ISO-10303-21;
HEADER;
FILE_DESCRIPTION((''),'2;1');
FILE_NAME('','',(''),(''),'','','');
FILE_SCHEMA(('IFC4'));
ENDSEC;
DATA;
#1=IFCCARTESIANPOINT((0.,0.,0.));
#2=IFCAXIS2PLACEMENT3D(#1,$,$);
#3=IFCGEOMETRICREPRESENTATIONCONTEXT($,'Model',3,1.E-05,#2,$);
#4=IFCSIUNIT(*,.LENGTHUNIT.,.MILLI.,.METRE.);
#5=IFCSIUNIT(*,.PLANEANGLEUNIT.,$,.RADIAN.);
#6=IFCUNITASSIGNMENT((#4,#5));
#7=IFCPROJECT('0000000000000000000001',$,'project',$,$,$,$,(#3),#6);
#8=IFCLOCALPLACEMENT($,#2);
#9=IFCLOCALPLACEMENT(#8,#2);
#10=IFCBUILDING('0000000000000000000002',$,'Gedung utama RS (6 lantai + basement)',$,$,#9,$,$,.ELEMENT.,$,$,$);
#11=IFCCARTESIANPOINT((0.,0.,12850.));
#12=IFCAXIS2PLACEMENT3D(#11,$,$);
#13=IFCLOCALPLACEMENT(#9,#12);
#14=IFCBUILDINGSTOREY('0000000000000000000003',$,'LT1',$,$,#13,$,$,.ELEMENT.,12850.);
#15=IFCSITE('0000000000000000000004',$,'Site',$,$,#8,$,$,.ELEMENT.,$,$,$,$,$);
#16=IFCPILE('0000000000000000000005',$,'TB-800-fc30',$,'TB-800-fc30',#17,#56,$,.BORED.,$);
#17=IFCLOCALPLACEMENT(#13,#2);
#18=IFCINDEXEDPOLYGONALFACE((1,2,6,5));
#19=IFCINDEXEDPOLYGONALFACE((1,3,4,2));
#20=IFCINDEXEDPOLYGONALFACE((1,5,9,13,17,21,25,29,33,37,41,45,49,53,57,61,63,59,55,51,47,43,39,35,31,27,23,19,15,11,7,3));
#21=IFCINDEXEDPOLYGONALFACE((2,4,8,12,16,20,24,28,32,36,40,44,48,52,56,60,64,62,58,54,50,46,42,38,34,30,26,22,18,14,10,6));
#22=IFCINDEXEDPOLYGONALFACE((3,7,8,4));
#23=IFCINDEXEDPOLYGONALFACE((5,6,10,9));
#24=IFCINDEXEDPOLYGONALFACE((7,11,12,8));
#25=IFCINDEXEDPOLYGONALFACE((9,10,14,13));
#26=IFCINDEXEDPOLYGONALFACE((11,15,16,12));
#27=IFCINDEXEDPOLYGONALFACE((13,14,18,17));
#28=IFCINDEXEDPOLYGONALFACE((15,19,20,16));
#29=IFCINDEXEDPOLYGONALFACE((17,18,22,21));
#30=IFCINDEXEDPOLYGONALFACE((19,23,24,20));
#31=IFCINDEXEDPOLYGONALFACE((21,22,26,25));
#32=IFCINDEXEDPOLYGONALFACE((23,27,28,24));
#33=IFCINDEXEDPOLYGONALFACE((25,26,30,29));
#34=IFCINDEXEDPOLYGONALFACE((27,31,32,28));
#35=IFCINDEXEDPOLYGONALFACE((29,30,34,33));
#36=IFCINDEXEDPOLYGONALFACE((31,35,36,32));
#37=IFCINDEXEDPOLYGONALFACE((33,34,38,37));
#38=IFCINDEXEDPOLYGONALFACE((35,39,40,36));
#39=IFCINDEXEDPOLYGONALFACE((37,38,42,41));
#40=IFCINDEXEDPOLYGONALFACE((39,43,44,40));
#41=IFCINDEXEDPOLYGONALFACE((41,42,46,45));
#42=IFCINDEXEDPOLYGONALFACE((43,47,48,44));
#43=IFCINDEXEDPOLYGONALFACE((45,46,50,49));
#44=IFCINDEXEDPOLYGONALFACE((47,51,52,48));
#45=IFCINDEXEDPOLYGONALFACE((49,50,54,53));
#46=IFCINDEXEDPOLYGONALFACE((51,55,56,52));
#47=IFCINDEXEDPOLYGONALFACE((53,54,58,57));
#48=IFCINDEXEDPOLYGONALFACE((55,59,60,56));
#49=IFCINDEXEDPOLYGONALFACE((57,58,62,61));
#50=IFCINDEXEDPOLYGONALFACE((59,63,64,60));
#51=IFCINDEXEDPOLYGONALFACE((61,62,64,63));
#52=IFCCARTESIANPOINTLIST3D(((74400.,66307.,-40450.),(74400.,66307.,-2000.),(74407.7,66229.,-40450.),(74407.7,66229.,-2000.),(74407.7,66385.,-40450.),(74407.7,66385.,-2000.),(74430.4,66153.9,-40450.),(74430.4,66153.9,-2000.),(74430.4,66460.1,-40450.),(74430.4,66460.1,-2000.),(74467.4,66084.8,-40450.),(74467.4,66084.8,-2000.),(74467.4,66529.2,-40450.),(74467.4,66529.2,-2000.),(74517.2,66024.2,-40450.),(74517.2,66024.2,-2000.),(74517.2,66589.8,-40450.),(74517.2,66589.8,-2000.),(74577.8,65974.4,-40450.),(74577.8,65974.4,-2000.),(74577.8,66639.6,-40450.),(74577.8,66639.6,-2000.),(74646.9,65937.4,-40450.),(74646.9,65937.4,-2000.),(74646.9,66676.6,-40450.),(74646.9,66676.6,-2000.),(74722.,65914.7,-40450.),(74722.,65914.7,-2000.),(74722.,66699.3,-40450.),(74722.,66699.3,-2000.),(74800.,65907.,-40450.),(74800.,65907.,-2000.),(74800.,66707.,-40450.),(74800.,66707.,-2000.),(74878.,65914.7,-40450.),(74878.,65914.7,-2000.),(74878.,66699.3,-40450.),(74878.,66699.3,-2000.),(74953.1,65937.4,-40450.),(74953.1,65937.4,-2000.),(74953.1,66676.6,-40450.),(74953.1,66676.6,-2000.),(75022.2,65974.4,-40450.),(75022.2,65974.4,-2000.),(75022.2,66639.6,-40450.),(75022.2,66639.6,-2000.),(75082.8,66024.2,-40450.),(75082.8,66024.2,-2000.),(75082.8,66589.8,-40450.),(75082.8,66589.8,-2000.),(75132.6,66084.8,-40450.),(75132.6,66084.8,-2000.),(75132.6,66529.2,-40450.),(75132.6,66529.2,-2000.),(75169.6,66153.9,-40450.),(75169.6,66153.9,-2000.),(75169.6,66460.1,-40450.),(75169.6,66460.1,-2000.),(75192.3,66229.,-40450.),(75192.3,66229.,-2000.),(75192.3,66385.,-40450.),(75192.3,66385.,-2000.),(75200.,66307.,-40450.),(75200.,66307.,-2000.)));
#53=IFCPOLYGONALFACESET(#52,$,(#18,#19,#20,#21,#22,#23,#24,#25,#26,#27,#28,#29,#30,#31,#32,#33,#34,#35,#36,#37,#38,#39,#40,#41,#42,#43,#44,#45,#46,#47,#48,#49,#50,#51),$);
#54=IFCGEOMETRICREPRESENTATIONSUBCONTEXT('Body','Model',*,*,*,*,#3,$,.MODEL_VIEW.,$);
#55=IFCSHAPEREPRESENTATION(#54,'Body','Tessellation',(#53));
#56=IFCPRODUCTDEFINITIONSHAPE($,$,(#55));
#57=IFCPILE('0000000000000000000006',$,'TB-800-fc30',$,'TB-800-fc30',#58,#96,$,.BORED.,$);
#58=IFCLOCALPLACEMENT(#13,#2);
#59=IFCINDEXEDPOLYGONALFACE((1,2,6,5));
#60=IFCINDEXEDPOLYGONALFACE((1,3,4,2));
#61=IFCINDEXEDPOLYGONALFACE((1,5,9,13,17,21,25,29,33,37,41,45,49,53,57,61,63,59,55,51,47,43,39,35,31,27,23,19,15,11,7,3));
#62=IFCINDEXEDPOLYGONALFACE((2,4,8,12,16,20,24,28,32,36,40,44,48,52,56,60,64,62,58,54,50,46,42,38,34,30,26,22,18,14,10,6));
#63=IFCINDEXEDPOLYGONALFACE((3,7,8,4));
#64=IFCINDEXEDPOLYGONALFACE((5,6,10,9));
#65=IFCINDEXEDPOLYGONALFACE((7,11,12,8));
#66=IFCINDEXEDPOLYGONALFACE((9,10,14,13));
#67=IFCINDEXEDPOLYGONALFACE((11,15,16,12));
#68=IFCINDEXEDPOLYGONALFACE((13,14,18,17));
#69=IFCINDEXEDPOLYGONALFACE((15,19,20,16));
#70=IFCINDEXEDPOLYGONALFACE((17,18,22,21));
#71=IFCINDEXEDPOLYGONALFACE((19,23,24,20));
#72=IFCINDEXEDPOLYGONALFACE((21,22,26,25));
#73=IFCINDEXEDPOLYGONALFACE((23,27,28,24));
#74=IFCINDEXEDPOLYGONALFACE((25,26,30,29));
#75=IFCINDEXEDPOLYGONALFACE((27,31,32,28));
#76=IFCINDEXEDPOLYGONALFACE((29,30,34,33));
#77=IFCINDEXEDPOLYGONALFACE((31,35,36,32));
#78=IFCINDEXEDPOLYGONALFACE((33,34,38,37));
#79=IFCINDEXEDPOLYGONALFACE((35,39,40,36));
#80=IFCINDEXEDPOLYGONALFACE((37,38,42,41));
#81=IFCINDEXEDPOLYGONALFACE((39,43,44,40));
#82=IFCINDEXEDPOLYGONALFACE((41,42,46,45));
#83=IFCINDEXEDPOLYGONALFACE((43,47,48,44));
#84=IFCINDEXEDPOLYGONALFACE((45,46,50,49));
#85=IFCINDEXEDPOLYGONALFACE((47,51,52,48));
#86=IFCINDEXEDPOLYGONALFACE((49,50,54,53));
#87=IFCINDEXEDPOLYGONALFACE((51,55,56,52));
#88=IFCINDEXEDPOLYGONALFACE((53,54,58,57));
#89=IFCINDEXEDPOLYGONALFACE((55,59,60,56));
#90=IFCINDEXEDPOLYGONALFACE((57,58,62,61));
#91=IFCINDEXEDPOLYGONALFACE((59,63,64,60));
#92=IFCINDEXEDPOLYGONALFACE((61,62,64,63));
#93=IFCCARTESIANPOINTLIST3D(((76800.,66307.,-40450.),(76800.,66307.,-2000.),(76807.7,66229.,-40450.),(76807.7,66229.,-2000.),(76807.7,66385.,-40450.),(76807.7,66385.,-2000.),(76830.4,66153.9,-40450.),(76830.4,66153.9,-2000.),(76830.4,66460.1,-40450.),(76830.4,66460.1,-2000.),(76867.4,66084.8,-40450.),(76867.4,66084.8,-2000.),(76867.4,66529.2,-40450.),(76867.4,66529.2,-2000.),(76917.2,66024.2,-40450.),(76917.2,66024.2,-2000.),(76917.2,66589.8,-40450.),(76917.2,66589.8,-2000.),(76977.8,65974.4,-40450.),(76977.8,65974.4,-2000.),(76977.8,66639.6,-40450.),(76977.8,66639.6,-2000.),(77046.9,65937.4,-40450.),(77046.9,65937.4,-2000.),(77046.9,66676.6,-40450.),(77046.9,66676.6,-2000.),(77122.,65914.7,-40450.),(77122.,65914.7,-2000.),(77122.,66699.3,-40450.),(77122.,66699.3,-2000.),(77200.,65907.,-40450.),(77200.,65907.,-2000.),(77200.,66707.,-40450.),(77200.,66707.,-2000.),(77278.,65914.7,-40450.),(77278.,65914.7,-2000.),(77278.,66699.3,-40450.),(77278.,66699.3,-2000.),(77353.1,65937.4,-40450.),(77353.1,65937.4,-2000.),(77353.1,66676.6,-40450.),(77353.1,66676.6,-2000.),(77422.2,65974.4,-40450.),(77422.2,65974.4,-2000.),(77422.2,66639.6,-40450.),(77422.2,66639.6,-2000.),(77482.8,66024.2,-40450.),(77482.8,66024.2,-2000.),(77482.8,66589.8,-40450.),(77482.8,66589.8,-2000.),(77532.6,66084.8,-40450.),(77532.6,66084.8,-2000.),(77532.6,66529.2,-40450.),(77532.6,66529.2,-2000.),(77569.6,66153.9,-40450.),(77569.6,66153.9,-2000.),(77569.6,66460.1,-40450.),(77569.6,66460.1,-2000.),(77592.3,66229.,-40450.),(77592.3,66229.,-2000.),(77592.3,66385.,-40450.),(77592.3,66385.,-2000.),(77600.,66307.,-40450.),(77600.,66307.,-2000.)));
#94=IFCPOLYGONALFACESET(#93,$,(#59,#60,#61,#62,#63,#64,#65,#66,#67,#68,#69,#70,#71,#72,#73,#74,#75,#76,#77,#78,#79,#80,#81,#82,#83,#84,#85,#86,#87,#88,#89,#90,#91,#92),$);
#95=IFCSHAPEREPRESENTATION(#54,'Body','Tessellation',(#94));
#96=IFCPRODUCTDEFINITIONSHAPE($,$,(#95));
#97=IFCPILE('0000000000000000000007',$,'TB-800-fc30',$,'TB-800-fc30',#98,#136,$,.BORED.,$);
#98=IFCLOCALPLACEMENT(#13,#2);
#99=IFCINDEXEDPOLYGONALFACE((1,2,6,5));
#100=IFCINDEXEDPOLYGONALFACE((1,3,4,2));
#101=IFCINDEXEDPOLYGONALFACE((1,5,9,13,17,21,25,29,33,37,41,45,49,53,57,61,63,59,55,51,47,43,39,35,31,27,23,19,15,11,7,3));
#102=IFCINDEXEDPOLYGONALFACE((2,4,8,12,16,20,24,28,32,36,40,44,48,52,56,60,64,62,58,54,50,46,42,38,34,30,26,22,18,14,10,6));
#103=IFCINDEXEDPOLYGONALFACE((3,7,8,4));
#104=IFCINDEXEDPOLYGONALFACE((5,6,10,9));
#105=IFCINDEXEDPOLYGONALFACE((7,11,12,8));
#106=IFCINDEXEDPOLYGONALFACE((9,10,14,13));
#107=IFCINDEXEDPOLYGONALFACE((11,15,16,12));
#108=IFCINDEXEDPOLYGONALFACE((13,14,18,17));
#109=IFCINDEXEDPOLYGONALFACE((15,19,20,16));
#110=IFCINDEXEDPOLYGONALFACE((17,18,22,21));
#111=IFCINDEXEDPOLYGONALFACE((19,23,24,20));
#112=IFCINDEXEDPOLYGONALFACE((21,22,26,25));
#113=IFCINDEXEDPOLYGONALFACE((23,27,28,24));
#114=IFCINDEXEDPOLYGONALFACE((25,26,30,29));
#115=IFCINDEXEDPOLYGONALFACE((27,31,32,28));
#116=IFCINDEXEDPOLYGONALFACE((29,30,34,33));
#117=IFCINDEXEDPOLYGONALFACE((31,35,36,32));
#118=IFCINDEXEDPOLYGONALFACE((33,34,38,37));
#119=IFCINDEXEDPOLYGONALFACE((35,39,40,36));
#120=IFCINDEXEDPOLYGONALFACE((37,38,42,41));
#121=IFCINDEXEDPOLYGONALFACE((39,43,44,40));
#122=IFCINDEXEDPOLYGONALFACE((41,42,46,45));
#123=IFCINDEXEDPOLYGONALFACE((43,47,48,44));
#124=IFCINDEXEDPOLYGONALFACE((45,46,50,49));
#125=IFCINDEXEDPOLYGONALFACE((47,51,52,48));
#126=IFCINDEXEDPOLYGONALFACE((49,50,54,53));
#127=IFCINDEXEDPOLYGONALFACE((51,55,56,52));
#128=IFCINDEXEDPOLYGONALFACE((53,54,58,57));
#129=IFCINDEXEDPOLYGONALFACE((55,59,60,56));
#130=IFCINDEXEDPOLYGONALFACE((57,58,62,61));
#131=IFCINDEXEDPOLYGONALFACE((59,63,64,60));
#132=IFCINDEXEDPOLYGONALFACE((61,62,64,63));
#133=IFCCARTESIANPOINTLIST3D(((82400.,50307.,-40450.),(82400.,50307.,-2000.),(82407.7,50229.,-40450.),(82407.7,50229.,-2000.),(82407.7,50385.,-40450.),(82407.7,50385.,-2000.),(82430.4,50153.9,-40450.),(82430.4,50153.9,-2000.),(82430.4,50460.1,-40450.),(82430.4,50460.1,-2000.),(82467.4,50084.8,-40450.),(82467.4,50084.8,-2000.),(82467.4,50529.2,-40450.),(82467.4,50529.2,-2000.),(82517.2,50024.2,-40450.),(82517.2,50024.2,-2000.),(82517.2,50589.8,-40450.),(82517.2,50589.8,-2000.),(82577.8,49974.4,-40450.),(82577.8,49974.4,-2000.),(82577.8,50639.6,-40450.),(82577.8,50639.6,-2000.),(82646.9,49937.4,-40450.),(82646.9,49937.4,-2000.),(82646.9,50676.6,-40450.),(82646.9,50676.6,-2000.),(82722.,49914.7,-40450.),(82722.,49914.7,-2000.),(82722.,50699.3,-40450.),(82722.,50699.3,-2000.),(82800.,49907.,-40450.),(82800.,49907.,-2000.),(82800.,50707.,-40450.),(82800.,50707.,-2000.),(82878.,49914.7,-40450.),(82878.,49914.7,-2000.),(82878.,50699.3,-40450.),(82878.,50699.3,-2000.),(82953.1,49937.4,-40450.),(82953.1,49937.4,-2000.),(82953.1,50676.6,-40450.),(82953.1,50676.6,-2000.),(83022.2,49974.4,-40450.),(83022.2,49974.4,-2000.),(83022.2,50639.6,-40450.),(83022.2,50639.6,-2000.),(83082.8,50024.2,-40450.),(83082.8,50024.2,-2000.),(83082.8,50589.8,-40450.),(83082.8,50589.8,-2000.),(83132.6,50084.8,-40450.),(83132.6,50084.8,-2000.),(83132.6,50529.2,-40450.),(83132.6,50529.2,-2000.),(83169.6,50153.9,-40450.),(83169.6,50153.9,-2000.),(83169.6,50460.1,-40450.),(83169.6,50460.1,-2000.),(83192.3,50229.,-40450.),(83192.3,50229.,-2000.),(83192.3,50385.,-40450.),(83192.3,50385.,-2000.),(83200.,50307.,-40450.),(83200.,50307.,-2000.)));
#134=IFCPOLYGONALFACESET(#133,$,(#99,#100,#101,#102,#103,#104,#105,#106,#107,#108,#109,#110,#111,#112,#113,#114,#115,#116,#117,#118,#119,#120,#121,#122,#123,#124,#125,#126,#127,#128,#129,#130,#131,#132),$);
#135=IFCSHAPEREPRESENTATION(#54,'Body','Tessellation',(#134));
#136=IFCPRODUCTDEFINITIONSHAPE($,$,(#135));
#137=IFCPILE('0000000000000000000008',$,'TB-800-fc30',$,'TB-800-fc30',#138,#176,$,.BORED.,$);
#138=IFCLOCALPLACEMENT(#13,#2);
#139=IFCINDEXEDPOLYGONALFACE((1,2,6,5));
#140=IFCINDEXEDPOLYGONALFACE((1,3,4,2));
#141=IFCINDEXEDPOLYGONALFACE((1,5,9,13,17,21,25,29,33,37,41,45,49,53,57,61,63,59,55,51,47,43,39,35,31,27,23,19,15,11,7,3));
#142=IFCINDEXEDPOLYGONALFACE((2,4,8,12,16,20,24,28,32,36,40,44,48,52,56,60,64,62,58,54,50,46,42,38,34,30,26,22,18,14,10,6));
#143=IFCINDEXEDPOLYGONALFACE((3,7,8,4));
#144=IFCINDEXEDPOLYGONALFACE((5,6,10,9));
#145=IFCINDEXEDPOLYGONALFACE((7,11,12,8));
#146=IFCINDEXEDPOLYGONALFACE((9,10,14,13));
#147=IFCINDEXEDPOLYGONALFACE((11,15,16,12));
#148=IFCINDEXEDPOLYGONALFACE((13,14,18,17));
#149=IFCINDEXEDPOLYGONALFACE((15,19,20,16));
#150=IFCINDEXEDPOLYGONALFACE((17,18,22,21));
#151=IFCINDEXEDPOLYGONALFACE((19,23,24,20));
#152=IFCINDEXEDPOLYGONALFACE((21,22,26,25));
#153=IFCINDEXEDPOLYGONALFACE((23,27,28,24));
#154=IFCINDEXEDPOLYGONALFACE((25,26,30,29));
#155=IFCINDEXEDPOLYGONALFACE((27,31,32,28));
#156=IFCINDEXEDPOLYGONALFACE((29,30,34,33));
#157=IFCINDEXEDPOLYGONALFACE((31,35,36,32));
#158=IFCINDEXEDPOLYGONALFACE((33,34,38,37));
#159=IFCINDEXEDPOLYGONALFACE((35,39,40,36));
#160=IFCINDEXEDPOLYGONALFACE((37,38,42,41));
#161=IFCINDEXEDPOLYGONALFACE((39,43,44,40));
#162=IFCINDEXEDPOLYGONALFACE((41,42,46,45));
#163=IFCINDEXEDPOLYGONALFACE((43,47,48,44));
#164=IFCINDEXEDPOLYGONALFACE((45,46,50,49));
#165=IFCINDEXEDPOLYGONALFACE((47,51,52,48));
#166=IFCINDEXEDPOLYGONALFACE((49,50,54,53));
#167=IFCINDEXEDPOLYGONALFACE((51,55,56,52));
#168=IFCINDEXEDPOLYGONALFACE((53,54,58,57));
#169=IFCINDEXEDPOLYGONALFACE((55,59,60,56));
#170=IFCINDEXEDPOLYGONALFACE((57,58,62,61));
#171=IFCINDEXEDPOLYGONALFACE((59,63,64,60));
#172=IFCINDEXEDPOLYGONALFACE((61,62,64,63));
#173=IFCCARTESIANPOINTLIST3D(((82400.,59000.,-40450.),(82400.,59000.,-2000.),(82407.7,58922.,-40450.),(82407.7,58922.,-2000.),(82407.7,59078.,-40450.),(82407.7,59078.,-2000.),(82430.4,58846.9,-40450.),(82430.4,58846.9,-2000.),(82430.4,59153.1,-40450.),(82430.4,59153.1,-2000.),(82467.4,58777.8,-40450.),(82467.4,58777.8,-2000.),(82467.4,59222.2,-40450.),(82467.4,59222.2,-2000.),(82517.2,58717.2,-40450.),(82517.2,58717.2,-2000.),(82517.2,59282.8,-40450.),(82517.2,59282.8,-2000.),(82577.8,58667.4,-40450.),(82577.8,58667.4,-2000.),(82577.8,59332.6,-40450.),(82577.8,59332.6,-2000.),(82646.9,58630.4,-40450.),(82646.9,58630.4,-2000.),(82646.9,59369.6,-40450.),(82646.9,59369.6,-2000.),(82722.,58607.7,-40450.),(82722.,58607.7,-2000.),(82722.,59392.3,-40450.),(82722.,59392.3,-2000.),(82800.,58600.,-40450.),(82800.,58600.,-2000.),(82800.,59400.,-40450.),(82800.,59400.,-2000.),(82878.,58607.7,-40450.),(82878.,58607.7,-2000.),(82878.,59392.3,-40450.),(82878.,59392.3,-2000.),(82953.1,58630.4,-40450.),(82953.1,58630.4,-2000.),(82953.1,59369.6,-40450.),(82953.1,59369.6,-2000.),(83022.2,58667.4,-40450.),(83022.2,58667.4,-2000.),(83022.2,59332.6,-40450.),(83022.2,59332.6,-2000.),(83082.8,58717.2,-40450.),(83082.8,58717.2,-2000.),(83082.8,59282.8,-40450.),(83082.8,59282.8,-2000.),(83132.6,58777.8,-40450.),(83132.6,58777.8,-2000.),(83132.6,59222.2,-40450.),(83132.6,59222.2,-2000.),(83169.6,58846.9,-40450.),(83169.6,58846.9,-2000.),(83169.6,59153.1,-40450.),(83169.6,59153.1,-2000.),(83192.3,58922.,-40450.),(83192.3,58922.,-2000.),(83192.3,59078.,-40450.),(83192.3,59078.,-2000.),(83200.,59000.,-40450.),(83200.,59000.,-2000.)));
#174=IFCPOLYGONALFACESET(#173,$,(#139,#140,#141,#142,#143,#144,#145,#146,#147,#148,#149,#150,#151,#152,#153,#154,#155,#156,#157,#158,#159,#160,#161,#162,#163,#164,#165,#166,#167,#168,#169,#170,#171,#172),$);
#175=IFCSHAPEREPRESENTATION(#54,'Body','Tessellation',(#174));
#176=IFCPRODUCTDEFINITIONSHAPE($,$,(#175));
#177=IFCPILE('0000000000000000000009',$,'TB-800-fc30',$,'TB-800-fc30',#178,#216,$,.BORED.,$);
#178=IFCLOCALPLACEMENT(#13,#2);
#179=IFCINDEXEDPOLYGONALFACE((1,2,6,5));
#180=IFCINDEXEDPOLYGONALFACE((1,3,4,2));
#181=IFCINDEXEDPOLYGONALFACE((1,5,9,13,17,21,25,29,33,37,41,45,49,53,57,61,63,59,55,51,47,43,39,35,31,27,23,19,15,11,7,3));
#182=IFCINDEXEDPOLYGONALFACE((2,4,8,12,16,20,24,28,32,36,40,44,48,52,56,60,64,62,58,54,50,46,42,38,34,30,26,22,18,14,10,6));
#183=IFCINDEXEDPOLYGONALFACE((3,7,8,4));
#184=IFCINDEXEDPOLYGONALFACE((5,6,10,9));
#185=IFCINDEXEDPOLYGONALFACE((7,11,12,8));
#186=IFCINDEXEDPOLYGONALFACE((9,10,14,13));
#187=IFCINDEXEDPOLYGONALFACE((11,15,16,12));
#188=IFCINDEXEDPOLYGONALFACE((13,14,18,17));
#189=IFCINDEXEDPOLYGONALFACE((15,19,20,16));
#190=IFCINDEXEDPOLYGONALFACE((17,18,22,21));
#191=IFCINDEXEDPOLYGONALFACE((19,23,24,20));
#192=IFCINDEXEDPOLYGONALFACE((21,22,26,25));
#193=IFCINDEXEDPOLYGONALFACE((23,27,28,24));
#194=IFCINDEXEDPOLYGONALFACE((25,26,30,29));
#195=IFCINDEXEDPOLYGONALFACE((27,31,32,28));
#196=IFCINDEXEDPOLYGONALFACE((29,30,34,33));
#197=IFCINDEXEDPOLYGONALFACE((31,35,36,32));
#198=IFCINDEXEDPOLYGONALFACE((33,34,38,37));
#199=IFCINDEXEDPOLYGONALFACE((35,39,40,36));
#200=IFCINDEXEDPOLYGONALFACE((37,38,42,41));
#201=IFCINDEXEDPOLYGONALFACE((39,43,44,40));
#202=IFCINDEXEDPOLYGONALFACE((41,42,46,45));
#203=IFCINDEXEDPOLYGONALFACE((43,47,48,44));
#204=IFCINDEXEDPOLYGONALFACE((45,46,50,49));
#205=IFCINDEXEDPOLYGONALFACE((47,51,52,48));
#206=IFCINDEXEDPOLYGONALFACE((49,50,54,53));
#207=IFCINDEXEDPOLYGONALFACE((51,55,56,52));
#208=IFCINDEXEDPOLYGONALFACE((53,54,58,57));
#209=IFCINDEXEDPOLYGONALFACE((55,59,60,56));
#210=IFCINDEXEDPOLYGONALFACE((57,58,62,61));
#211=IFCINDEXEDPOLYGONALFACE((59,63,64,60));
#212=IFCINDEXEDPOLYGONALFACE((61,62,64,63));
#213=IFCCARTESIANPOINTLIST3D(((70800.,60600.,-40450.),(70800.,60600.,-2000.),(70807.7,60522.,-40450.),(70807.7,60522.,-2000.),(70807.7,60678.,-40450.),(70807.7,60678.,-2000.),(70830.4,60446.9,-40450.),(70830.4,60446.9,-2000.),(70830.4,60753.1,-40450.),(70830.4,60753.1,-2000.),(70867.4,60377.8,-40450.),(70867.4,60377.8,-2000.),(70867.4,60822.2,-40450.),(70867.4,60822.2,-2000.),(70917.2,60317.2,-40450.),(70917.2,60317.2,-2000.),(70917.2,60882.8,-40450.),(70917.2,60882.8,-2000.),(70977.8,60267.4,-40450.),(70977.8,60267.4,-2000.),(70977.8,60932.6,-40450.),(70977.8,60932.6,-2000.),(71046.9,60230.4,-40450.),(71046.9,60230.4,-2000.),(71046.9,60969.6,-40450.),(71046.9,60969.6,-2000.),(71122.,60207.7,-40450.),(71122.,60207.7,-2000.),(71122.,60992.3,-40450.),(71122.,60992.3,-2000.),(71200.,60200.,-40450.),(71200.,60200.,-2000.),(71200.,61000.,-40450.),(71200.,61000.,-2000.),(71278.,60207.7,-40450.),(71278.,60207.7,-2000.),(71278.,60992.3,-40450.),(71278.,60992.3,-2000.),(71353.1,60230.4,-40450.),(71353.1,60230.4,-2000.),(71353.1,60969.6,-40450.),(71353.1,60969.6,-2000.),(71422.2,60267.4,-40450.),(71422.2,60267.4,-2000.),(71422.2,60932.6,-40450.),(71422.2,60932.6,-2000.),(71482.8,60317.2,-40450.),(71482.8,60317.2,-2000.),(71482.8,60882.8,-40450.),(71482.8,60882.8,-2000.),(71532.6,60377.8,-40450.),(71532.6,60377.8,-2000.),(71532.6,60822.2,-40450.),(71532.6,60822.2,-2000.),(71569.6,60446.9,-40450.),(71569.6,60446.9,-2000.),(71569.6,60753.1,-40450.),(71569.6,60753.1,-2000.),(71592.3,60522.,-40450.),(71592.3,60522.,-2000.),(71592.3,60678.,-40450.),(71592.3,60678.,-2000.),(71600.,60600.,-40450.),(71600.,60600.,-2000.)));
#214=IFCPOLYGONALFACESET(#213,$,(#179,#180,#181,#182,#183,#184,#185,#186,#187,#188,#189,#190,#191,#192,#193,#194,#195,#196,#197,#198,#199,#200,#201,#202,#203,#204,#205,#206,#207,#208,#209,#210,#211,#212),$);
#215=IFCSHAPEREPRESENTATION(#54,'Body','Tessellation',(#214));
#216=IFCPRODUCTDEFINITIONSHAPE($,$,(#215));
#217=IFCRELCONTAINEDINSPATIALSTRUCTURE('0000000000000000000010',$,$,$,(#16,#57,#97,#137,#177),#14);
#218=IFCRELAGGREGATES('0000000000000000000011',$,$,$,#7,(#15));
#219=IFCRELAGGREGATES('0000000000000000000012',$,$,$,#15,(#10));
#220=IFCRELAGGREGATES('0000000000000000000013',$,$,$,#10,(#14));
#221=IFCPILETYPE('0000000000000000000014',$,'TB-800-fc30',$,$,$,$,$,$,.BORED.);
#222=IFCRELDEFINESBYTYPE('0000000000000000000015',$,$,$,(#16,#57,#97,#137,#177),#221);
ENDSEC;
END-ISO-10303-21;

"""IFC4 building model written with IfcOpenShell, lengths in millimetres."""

from ifc_helpers import new_model, si_unit, frame, origin, origin_2d, place, context, subcontext, project, spatial, circle, extrude, material_profile, profile_set, profile_usage, type_object, element, save


model = new_model("IFC4")

# Units and contexts
model_context = context("Model", 3, precision=1e-05, world=origin())
body_context = subcontext(model_context, "Body", "Model", "MODEL_VIEW")
ifc_project = project(units=[si_unit("LENGTHUNIT", "METRE", prefix="MILLI"), si_unit("PLANEANGLEUNIT", "RADIAN")], contexts=[model_context])

# Site, building, storey
site_placement = place(None, origin())
site = spatial("IfcSite", under=ifc_project, at=site_placement, Name="Site", CompositionType="ELEMENT")
building_placement = place(site_placement, origin())
building = spatial("IfcBuilding", under=site, at=building_placement, Name="Gedung utama RS (6 lantai + basement)", CompositionType="ELEMENT")
storey_placement = place(building_placement, frame((0.0, 0.0, 12850.0)))
storey = spatial("IfcBuildingStorey", under=building, at=storey_placement, Name="LT1", CompositionType="ELEMENT", Elevation=12850.0)

# Piles
ifc_material_profile = material_profile(None, circle(Radius=400.0, at=origin_2d()), Name="TB-800-fc30")
ifc_profile_set = profile_set([ifc_material_profile], Name="TB-800-fc30")
ifc_profile_usage = profile_usage(ifc_profile_set, cardinal=5)
pile_type = type_object("IfcPileType", Name="TB-800-fc30", PredefinedType="BORED", material=ifc_profile_set)
for number, where, z_axis, x_axis, name in (
    (1, (74800.0, 66307.0, -40450.0), (0.0, 0.0, 1.0), (1.0, 0.0, 0.0), "TB-800-fc30"),
    (2, (77200.0, 66307.0, -40450.0), (0.0, 0.0, 1.0), (1.0, 0.0, 0.0), "TB-800-fc30"),
    (3, (82800.0, 50307.0, -40450.0), (0.0, 0.0, 1.0), (1.0, 0.0, 0.0), "TB-800-fc30"),
    (4, (82800.0, 59000.0, -40450.0), (0.0, 0.0, 1.0), (1.0, 0.0, 0.0), "TB-800-fc30"),
    (5, (71200.0, 60600.0, -40450.0), (0.0, 0.0, 1.0), (1.0, 0.0, 0.0), "TB-800-fc30"),
):
    element("IfcPile", number, at=place(storey_placement, frame(where, z_axis=z_axis, x_axis=x_axis)), inside=storey, type_object=pile_type, material=ifc_profile_usage, Name=name, ObjectType="TB-800-fc30", PredefinedType="BORED", context=body_context, shape_type="SweptSolid", body=[
        extrude(circle(Radius=400.0, at=origin_2d()), origin(), (0.0, 0.0, 1.0), 38450.0),
    ])

save(model, "model.ifc")
